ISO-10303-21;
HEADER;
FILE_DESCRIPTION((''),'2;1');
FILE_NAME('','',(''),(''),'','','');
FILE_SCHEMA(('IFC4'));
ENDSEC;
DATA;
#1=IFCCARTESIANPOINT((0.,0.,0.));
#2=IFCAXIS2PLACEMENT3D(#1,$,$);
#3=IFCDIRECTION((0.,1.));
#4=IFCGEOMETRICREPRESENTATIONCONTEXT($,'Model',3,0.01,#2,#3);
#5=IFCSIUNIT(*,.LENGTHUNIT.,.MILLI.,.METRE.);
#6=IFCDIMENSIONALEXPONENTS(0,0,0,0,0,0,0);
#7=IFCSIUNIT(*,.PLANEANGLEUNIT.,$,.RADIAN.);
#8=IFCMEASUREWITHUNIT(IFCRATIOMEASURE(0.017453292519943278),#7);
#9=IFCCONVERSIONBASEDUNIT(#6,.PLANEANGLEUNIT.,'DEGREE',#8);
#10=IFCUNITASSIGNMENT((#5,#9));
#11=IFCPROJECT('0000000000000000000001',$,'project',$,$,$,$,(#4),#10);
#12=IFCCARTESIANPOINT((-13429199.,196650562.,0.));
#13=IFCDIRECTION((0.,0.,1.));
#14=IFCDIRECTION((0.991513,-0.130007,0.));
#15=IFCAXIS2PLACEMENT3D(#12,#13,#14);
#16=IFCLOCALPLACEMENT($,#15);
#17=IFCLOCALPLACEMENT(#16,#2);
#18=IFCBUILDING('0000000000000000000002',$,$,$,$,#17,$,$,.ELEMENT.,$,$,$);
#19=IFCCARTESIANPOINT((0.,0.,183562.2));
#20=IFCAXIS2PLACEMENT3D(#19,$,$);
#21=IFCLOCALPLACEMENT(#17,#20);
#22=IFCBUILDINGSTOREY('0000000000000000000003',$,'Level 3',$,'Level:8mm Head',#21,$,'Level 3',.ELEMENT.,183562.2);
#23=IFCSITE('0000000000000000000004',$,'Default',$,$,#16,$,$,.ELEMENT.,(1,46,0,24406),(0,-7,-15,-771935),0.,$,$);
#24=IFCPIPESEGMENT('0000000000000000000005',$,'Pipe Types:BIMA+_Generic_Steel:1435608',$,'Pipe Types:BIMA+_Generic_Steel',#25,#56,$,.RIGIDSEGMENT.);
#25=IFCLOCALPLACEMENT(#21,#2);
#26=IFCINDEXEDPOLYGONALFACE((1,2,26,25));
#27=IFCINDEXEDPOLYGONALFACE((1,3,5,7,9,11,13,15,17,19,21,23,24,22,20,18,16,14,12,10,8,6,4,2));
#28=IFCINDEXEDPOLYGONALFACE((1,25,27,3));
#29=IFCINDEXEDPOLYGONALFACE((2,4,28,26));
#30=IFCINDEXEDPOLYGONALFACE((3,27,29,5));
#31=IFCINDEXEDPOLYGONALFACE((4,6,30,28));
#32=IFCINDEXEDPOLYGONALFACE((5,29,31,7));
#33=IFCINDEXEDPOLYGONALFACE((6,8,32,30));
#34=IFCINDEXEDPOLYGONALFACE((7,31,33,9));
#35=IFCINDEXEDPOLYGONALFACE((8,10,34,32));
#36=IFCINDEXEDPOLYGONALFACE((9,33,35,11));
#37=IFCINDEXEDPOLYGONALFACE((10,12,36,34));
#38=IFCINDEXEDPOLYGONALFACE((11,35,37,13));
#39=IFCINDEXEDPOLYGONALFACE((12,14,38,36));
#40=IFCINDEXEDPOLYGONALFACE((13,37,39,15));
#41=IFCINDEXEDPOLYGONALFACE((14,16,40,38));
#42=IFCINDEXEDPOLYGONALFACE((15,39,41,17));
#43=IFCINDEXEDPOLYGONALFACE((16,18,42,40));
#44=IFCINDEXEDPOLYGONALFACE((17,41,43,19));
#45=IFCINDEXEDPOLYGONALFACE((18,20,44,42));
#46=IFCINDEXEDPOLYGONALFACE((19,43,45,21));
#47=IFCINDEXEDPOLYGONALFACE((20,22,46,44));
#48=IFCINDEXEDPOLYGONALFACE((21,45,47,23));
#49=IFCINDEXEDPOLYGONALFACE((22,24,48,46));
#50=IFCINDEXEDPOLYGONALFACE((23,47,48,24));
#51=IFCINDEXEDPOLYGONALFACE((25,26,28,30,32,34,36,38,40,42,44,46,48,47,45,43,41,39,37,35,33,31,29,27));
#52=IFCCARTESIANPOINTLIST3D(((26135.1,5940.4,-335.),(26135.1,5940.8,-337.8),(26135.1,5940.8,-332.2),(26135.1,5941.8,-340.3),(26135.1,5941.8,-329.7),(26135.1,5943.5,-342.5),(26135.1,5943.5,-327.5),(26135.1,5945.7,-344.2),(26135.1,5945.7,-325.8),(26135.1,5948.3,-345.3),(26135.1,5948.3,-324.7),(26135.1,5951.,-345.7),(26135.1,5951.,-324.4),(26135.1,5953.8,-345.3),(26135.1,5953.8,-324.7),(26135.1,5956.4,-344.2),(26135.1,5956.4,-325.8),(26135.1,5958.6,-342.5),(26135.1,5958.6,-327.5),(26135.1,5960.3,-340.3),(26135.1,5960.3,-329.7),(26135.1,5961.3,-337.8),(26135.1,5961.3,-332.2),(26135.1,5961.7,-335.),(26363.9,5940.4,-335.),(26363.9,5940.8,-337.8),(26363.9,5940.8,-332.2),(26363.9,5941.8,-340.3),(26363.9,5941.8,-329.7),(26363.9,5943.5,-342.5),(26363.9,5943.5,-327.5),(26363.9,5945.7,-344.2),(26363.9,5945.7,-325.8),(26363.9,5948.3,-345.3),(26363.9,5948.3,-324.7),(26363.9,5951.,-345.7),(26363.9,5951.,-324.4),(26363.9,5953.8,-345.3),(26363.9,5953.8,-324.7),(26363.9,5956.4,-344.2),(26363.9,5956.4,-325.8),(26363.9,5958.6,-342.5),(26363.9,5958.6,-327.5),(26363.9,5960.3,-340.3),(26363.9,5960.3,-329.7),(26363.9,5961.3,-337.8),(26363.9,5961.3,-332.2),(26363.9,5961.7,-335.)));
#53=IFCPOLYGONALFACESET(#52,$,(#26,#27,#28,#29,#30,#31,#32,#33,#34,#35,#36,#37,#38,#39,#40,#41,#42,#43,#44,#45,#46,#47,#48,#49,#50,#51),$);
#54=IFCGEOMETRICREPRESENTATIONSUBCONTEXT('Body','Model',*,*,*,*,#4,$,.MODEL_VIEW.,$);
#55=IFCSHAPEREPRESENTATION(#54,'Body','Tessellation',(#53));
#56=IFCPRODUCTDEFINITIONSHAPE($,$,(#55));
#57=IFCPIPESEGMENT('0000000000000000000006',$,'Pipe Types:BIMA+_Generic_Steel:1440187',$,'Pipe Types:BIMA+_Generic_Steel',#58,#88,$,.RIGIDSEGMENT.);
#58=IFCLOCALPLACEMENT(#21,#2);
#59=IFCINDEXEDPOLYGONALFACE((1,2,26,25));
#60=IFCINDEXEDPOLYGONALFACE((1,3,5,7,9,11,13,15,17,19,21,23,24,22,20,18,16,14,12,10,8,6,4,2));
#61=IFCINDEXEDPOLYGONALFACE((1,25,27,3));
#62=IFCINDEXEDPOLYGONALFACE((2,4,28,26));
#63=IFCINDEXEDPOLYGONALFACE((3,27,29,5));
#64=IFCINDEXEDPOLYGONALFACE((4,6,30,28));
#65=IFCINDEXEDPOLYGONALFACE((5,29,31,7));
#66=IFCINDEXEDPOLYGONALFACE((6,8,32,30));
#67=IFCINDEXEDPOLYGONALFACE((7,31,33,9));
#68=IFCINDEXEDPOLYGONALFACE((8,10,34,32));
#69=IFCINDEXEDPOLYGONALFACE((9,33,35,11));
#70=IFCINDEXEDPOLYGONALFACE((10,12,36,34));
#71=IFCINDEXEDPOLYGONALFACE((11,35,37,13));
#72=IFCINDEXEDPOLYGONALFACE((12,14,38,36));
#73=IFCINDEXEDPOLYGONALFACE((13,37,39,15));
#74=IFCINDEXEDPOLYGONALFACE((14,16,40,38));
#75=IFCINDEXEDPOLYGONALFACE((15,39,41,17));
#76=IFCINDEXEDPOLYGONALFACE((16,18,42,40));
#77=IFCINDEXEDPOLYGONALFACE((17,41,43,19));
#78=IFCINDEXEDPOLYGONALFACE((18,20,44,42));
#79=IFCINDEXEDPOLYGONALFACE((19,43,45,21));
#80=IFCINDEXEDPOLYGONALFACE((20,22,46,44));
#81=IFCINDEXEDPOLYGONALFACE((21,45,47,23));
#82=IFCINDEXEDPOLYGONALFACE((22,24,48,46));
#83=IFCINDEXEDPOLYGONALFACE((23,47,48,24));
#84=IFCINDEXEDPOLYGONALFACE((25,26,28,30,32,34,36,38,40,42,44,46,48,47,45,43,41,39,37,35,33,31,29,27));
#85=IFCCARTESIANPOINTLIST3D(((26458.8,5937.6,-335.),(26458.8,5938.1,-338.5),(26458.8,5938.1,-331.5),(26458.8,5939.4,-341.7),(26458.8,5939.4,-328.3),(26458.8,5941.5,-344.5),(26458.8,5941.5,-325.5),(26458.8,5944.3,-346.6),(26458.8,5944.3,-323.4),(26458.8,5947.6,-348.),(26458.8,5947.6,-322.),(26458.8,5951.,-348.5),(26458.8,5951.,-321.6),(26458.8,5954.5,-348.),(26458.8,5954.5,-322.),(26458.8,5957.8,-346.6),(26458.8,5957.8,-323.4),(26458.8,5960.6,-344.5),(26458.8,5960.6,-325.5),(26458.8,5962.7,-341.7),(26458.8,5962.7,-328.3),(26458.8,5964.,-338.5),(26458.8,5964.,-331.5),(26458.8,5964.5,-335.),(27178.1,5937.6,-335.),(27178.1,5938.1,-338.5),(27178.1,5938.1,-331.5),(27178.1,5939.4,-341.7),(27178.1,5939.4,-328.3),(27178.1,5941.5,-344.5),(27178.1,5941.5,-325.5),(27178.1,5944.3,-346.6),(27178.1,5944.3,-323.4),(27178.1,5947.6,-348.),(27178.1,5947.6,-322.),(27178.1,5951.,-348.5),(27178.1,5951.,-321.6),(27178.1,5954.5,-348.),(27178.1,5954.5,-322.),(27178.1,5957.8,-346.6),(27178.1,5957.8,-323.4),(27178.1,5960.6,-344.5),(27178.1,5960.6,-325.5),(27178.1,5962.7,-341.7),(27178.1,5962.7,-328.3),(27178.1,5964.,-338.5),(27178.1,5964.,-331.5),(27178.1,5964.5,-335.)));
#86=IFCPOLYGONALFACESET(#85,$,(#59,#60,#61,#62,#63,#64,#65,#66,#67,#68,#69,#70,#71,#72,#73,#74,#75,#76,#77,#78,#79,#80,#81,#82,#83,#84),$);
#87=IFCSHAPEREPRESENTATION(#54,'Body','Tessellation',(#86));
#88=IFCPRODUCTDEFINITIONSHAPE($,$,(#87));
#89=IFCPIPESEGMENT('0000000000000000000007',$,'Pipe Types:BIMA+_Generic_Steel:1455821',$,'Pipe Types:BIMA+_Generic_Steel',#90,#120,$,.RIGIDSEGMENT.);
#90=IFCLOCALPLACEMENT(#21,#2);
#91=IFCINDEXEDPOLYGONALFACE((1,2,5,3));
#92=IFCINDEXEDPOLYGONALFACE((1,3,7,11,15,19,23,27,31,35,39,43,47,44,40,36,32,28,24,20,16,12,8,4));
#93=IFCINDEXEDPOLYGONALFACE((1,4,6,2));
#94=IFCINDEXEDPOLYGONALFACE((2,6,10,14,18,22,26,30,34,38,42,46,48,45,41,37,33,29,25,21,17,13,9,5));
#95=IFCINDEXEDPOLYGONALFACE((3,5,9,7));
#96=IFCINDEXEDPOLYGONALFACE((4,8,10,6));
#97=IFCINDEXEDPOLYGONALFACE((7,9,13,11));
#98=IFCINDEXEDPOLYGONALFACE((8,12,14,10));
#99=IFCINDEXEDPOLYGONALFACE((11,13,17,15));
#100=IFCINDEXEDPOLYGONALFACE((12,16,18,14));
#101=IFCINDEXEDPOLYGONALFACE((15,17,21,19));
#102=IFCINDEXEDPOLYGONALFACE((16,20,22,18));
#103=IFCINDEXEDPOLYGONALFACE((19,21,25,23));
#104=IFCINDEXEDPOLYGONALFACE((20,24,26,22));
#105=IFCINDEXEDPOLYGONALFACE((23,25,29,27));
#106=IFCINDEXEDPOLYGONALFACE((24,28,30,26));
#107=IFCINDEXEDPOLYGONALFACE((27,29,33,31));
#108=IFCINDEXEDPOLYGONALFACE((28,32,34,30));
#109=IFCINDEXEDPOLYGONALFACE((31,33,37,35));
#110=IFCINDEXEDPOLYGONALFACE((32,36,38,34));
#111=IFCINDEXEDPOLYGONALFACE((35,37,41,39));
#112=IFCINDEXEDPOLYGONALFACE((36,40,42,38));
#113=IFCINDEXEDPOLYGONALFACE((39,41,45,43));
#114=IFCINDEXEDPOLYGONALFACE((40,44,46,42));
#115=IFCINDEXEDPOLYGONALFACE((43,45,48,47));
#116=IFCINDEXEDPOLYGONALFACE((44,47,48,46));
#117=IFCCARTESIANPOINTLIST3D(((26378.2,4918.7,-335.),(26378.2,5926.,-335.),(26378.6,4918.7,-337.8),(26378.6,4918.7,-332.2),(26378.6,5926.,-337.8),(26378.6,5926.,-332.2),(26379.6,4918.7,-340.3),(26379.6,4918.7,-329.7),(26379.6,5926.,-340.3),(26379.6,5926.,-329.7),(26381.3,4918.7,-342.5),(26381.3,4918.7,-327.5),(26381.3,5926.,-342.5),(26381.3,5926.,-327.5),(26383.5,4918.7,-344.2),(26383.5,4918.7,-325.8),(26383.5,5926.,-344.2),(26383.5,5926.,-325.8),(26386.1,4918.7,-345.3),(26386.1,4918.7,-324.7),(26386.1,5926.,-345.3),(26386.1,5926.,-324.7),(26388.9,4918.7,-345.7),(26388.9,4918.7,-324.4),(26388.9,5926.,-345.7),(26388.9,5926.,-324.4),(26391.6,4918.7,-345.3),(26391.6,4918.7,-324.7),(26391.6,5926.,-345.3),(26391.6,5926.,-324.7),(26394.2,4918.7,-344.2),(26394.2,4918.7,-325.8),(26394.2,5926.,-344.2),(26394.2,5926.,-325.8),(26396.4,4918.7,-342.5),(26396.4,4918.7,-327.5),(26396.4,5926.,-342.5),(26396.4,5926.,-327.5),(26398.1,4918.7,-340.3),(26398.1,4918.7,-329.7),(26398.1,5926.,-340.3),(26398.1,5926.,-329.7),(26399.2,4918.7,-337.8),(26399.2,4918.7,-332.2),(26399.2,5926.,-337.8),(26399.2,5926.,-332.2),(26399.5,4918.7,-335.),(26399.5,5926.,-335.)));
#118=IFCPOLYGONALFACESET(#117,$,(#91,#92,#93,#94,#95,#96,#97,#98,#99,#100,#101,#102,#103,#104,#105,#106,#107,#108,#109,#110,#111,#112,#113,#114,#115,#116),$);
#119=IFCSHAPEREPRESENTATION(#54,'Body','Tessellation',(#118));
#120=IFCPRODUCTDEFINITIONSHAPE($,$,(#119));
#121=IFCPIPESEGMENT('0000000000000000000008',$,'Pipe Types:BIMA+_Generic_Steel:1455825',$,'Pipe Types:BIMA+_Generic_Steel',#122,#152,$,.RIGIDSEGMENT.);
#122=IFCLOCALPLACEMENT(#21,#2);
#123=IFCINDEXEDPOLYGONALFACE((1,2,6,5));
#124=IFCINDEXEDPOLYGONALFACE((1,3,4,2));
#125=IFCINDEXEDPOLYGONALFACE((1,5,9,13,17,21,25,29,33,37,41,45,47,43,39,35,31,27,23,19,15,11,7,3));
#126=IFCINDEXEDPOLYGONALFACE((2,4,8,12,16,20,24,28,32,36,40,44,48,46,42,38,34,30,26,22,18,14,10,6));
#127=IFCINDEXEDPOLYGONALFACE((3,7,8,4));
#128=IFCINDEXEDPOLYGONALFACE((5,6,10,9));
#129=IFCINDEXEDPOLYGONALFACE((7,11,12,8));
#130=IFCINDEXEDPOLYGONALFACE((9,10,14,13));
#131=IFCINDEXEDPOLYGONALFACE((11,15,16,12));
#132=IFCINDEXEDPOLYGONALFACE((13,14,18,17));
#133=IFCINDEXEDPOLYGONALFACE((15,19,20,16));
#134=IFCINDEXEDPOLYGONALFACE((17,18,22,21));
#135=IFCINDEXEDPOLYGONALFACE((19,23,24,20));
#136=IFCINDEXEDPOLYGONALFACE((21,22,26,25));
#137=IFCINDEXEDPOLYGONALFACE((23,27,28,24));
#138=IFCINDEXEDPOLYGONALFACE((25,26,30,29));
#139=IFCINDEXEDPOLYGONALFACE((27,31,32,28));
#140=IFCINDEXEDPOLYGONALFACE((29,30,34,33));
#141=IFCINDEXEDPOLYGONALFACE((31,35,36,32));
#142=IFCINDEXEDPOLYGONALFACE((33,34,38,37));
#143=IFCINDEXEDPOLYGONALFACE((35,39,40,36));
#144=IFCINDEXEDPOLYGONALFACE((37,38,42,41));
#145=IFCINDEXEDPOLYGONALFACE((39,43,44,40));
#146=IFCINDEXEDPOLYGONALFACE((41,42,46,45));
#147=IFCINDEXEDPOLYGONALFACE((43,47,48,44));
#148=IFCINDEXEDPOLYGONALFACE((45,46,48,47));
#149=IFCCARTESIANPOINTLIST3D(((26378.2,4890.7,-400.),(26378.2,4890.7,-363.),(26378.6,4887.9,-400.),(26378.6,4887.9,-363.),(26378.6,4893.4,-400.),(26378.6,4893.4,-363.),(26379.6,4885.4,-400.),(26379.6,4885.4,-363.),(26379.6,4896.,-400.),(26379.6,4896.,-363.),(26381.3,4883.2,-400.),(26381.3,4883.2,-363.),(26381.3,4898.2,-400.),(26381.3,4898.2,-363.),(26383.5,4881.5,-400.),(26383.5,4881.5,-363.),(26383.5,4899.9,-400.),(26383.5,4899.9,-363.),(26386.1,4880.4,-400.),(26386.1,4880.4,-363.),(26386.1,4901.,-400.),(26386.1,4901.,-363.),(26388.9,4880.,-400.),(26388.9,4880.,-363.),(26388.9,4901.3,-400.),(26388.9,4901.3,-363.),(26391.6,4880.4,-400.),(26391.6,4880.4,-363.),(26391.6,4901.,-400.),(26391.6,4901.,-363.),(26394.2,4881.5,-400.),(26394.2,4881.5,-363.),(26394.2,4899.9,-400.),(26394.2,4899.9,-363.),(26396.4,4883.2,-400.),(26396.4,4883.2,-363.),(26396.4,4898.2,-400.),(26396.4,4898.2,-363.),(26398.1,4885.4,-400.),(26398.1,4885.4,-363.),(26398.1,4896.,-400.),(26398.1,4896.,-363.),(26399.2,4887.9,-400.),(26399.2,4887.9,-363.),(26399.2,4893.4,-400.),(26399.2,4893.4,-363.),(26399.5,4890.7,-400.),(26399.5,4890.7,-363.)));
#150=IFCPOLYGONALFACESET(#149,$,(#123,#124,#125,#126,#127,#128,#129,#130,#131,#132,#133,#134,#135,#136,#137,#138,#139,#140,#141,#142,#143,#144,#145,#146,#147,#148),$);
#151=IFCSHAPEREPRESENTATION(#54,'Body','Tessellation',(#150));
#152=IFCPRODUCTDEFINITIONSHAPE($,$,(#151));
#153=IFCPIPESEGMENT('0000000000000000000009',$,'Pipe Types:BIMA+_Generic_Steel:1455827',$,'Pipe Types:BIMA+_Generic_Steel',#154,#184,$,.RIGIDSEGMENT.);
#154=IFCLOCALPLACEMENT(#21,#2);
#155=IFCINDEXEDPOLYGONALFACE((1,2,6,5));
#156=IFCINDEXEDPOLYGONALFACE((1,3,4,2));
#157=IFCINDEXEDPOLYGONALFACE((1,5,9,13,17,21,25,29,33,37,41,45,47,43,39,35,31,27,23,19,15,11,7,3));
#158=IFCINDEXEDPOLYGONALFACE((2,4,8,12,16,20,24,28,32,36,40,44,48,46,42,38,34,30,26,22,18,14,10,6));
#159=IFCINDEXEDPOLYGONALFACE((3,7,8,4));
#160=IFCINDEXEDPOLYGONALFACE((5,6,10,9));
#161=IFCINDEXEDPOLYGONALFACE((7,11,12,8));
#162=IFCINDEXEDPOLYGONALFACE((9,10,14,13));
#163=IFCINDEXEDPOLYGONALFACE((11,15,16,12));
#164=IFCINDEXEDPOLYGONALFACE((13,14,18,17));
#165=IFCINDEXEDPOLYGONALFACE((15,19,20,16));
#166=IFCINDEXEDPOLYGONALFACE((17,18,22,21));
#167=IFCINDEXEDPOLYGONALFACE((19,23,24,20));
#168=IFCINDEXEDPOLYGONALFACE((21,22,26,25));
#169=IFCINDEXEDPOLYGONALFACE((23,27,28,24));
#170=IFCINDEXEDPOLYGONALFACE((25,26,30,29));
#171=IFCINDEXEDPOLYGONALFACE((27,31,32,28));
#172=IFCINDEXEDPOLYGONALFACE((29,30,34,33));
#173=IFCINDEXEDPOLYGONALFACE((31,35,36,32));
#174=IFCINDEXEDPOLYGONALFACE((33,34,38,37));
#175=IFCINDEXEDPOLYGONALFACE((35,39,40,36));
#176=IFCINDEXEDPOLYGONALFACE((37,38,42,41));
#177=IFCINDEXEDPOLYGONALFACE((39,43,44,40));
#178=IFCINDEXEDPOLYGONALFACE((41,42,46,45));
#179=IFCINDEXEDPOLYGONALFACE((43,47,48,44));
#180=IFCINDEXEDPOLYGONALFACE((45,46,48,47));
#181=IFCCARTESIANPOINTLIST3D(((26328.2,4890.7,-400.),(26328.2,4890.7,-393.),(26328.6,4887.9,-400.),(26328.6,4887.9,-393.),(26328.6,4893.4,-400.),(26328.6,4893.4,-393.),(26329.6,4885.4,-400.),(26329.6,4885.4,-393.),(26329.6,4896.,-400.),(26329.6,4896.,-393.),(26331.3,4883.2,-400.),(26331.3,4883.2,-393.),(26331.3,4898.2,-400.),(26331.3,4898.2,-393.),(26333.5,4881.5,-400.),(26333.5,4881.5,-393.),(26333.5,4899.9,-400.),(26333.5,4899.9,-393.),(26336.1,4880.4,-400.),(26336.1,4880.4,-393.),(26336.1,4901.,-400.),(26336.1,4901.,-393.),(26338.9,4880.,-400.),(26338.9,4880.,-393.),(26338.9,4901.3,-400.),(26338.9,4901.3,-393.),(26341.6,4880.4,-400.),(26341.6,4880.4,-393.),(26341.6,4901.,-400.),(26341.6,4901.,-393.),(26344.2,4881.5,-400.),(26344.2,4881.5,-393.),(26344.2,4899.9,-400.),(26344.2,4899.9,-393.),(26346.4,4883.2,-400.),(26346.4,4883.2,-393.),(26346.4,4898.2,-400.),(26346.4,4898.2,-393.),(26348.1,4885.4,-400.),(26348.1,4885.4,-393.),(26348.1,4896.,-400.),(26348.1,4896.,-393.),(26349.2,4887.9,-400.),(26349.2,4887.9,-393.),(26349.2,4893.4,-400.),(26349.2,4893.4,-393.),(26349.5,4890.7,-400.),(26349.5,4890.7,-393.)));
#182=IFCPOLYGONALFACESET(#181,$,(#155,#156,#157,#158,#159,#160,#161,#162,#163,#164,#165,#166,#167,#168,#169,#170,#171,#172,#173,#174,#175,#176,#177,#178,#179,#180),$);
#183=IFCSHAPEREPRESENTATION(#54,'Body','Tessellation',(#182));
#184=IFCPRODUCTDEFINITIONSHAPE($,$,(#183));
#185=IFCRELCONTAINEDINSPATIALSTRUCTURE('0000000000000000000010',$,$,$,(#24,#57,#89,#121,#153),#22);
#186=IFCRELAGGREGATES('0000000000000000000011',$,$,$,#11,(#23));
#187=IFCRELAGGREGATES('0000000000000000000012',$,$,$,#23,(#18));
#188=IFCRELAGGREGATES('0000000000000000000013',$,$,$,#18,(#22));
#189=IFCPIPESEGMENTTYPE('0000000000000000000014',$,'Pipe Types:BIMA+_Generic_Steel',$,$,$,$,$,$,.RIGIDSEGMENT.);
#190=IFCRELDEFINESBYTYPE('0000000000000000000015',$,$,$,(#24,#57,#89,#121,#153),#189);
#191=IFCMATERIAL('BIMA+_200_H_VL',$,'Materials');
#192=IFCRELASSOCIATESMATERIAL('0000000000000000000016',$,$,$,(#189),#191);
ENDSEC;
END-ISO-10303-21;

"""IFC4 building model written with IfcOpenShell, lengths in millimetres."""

from ifc_helpers import new_model, entity, si_unit, converted_unit, direction, frame, origin, place, context, subcontext, project, spatial, arc, indexed_curve, outline, extrude, material, type_object, element, save


model = new_model("IFC4")

# Units and contexts
model_context = context("Model", 3, precision=0.01, world=origin(), true_north=direction((0.0, 1.0)))
body_context = subcontext(model_context, "Body", "Model", "MODEL_VIEW")
ifc_project = project(units=[si_unit("LENGTHUNIT", "METRE", prefix="MILLI"), converted_unit("PLANEANGLEUNIT", "DEGREE", entity("IfcRatioMeasure", 0.017453292519943278), si_unit("PLANEANGLEUNIT", "RADIAN"), dimensions=[0, 0, 0, 0, 0, 0, 0])], contexts=[model_context])

# Site, building, storey
site_placement = place(None, frame((-13429199.0, 196650562.0, 0.0), z_axis=(0.0, 0.0, 1.0), x_axis=(0.991513, -0.130007, 0.0)))
site = spatial("IfcSite", under=ifc_project, at=site_placement, Name="Default", CompositionType="ELEMENT", RefLatitude=(1, 46, 0, 24406), RefLongitude=(0, -7, -15, -771935), RefElevation=0.0)
building_placement = place(site_placement, origin())
building = spatial("IfcBuilding", under=site, at=building_placement, CompositionType="ELEMENT")
storey_placement = place(building_placement, frame((0.0, 0.0, 183562.2)))
storey = spatial("IfcBuildingStorey", under=building, at=storey_placement, Name="Level 3", ObjectType="Level:8mm Head", LongName="Level 3", CompositionType="ELEMENT", Elevation=183562.2)

# Pipe segments
ifc_material_1 = material(Name="BIMA+_200_H_VL", Category="Materials")
pipe_segment_type = type_object("IfcPipeSegmentType", Name="Pipe Types:BIMA+_Generic_Steel", PredefinedType="RIGIDSEGMENT", material=ifc_material_1)
pipe_segment_1_placement = place(storey_placement, frame((26135.1, 5938.8, -347.2)))
element("IfcPipeSegment", 1, at=pipe_segment_1_placement, inside=storey, type_object=pipe_segment_type, Name="Pipe Types:BIMA+_Generic_Steel:1435608", ObjectType="Pipe Types:BIMA+_Generic_Steel", PredefinedType="RIGIDSEGMENT", context=body_context, shape_type="SweptSolid", body=[
    extrude(outline(indexed_curve([(10.6, 0.0), (7.5, 7.5), (0.0, 10.7), (-7.5, 7.5), (-10.6, 0.0), (-7.5, -7.5), (0.0, -10.7), (7.5, -7.5)], segments=[arc(1, 2, 3), arc(3, 4, 5), arc(5, 6, 7), arc(7, 8, 1)], self_intersect=False)), frame((0.0, 12.2, 12.2), z_axis=(1.0, 0.0, 0.0), x_axis=(0.0, 1.0, 0.0)), (0.0, 0.0, 1.0), 228.8),
])
pipe_segment_2_placement = place(storey_placement, frame((26458.8, 5936.0, -350.0)))
element("IfcPipeSegment", 2, at=pipe_segment_2_placement, inside=storey, type_object=pipe_segment_type, Name="Pipe Types:BIMA+_Generic_Steel:1440187", ObjectType="Pipe Types:BIMA+_Generic_Steel", PredefinedType="RIGIDSEGMENT", context=body_context, shape_type="SweptSolid", body=[
    extrude(outline(indexed_curve([(13.5, 0.0), (9.5, 9.5), (0.0, 13.5), (-9.5, 9.5), (-13.4, 0.0), (-9.5, -9.5), (0.0, -13.5), (9.5, -9.5)], segments=[arc(1, 2, 3), arc(3, 4, 5), arc(5, 6, 7), arc(7, 8, 1)], self_intersect=False)), frame((0.0, 15.0, 15.0), z_axis=(1.0, 0.0, 0.0), x_axis=(0.0, 1.0, 0.0)), (0.0, 0.0, 1.0), 719.3),
])
pipe_segment_3_placement = place(storey_placement, frame((26376.6, 4918.7, -347.2)))
element("IfcPipeSegment", 3, at=pipe_segment_3_placement, inside=storey, type_object=pipe_segment_type, Name="Pipe Types:BIMA+_Generic_Steel:1455821", ObjectType="Pipe Types:BIMA+_Generic_Steel", PredefinedType="RIGIDSEGMENT", context=body_context, shape_type="SweptSolid", body=[
    extrude(outline(indexed_curve([(10.7, 0.0), (7.5, 7.5), (0.0, 10.7), (-7.5, 7.5), (-10.7, 0.0), (-7.5, -7.5), (0.0, -10.7), (7.5, -7.5)], segments=[arc(1, 2, 3), arc(3, 4, 5), arc(5, 6, 7), arc(7, 8, 1)], self_intersect=False)), frame((12.2, 0.0, 12.2), z_axis=(0.0, 1.0, 0.0), x_axis=(-1.0, 0.0, 0.0)), (0.0, 0.0, 1.0), 1007.4),
])
pipe_segment_4_placement = place(storey_placement, frame((26376.6, 4878.4, -363.0)))
element("IfcPipeSegment", 4, at=pipe_segment_4_placement, inside=storey, type_object=pipe_segment_type, Name="Pipe Types:BIMA+_Generic_Steel:1455825", ObjectType="Pipe Types:BIMA+_Generic_Steel", PredefinedType="RIGIDSEGMENT", context=body_context, shape_type="SweptSolid", body=[
    extrude(outline(indexed_curve([(10.7, 0.0), (7.5, 7.5), (0.0, 10.6), (-7.5, 7.5), (-10.7, 0.0), (-7.5, -7.5), (0.0, -10.6), (7.5, -7.5)], segments=[arc(1, 2, 3), arc(3, 4, 5), arc(5, 6, 7), arc(7, 8, 1)], self_intersect=False)), frame((12.2, 12.2, -37.0)), (0.0, 0.0, 1.0), 37.0),
])
pipe_segment_5_placement = place(storey_placement, frame((26326.6, 4878.4, -393.0)))
element("IfcPipeSegment", 5, at=pipe_segment_5_placement, inside=storey, type_object=pipe_segment_type, Name="Pipe Types:BIMA+_Generic_Steel:1455827", ObjectType="Pipe Types:BIMA+_Generic_Steel", PredefinedType="RIGIDSEGMENT", context=body_context, shape_type="SweptSolid", body=[
    extrude(outline(indexed_curve([(10.7, 0.0), (7.5, 7.5), (0.0, 10.6), (-7.5, 7.5), (-10.7, 0.0), (-7.5, -7.5), (0.0, -10.6), (7.5, -7.5)], segments=[arc(1, 2, 3), arc(3, 4, 5), arc(5, 6, 7), arc(7, 8, 1)], self_intersect=False)), frame((12.2, 12.2, -7.0)), (0.0, 0.0, 1.0), 7.0),
])

save(model, "model.ifc")
